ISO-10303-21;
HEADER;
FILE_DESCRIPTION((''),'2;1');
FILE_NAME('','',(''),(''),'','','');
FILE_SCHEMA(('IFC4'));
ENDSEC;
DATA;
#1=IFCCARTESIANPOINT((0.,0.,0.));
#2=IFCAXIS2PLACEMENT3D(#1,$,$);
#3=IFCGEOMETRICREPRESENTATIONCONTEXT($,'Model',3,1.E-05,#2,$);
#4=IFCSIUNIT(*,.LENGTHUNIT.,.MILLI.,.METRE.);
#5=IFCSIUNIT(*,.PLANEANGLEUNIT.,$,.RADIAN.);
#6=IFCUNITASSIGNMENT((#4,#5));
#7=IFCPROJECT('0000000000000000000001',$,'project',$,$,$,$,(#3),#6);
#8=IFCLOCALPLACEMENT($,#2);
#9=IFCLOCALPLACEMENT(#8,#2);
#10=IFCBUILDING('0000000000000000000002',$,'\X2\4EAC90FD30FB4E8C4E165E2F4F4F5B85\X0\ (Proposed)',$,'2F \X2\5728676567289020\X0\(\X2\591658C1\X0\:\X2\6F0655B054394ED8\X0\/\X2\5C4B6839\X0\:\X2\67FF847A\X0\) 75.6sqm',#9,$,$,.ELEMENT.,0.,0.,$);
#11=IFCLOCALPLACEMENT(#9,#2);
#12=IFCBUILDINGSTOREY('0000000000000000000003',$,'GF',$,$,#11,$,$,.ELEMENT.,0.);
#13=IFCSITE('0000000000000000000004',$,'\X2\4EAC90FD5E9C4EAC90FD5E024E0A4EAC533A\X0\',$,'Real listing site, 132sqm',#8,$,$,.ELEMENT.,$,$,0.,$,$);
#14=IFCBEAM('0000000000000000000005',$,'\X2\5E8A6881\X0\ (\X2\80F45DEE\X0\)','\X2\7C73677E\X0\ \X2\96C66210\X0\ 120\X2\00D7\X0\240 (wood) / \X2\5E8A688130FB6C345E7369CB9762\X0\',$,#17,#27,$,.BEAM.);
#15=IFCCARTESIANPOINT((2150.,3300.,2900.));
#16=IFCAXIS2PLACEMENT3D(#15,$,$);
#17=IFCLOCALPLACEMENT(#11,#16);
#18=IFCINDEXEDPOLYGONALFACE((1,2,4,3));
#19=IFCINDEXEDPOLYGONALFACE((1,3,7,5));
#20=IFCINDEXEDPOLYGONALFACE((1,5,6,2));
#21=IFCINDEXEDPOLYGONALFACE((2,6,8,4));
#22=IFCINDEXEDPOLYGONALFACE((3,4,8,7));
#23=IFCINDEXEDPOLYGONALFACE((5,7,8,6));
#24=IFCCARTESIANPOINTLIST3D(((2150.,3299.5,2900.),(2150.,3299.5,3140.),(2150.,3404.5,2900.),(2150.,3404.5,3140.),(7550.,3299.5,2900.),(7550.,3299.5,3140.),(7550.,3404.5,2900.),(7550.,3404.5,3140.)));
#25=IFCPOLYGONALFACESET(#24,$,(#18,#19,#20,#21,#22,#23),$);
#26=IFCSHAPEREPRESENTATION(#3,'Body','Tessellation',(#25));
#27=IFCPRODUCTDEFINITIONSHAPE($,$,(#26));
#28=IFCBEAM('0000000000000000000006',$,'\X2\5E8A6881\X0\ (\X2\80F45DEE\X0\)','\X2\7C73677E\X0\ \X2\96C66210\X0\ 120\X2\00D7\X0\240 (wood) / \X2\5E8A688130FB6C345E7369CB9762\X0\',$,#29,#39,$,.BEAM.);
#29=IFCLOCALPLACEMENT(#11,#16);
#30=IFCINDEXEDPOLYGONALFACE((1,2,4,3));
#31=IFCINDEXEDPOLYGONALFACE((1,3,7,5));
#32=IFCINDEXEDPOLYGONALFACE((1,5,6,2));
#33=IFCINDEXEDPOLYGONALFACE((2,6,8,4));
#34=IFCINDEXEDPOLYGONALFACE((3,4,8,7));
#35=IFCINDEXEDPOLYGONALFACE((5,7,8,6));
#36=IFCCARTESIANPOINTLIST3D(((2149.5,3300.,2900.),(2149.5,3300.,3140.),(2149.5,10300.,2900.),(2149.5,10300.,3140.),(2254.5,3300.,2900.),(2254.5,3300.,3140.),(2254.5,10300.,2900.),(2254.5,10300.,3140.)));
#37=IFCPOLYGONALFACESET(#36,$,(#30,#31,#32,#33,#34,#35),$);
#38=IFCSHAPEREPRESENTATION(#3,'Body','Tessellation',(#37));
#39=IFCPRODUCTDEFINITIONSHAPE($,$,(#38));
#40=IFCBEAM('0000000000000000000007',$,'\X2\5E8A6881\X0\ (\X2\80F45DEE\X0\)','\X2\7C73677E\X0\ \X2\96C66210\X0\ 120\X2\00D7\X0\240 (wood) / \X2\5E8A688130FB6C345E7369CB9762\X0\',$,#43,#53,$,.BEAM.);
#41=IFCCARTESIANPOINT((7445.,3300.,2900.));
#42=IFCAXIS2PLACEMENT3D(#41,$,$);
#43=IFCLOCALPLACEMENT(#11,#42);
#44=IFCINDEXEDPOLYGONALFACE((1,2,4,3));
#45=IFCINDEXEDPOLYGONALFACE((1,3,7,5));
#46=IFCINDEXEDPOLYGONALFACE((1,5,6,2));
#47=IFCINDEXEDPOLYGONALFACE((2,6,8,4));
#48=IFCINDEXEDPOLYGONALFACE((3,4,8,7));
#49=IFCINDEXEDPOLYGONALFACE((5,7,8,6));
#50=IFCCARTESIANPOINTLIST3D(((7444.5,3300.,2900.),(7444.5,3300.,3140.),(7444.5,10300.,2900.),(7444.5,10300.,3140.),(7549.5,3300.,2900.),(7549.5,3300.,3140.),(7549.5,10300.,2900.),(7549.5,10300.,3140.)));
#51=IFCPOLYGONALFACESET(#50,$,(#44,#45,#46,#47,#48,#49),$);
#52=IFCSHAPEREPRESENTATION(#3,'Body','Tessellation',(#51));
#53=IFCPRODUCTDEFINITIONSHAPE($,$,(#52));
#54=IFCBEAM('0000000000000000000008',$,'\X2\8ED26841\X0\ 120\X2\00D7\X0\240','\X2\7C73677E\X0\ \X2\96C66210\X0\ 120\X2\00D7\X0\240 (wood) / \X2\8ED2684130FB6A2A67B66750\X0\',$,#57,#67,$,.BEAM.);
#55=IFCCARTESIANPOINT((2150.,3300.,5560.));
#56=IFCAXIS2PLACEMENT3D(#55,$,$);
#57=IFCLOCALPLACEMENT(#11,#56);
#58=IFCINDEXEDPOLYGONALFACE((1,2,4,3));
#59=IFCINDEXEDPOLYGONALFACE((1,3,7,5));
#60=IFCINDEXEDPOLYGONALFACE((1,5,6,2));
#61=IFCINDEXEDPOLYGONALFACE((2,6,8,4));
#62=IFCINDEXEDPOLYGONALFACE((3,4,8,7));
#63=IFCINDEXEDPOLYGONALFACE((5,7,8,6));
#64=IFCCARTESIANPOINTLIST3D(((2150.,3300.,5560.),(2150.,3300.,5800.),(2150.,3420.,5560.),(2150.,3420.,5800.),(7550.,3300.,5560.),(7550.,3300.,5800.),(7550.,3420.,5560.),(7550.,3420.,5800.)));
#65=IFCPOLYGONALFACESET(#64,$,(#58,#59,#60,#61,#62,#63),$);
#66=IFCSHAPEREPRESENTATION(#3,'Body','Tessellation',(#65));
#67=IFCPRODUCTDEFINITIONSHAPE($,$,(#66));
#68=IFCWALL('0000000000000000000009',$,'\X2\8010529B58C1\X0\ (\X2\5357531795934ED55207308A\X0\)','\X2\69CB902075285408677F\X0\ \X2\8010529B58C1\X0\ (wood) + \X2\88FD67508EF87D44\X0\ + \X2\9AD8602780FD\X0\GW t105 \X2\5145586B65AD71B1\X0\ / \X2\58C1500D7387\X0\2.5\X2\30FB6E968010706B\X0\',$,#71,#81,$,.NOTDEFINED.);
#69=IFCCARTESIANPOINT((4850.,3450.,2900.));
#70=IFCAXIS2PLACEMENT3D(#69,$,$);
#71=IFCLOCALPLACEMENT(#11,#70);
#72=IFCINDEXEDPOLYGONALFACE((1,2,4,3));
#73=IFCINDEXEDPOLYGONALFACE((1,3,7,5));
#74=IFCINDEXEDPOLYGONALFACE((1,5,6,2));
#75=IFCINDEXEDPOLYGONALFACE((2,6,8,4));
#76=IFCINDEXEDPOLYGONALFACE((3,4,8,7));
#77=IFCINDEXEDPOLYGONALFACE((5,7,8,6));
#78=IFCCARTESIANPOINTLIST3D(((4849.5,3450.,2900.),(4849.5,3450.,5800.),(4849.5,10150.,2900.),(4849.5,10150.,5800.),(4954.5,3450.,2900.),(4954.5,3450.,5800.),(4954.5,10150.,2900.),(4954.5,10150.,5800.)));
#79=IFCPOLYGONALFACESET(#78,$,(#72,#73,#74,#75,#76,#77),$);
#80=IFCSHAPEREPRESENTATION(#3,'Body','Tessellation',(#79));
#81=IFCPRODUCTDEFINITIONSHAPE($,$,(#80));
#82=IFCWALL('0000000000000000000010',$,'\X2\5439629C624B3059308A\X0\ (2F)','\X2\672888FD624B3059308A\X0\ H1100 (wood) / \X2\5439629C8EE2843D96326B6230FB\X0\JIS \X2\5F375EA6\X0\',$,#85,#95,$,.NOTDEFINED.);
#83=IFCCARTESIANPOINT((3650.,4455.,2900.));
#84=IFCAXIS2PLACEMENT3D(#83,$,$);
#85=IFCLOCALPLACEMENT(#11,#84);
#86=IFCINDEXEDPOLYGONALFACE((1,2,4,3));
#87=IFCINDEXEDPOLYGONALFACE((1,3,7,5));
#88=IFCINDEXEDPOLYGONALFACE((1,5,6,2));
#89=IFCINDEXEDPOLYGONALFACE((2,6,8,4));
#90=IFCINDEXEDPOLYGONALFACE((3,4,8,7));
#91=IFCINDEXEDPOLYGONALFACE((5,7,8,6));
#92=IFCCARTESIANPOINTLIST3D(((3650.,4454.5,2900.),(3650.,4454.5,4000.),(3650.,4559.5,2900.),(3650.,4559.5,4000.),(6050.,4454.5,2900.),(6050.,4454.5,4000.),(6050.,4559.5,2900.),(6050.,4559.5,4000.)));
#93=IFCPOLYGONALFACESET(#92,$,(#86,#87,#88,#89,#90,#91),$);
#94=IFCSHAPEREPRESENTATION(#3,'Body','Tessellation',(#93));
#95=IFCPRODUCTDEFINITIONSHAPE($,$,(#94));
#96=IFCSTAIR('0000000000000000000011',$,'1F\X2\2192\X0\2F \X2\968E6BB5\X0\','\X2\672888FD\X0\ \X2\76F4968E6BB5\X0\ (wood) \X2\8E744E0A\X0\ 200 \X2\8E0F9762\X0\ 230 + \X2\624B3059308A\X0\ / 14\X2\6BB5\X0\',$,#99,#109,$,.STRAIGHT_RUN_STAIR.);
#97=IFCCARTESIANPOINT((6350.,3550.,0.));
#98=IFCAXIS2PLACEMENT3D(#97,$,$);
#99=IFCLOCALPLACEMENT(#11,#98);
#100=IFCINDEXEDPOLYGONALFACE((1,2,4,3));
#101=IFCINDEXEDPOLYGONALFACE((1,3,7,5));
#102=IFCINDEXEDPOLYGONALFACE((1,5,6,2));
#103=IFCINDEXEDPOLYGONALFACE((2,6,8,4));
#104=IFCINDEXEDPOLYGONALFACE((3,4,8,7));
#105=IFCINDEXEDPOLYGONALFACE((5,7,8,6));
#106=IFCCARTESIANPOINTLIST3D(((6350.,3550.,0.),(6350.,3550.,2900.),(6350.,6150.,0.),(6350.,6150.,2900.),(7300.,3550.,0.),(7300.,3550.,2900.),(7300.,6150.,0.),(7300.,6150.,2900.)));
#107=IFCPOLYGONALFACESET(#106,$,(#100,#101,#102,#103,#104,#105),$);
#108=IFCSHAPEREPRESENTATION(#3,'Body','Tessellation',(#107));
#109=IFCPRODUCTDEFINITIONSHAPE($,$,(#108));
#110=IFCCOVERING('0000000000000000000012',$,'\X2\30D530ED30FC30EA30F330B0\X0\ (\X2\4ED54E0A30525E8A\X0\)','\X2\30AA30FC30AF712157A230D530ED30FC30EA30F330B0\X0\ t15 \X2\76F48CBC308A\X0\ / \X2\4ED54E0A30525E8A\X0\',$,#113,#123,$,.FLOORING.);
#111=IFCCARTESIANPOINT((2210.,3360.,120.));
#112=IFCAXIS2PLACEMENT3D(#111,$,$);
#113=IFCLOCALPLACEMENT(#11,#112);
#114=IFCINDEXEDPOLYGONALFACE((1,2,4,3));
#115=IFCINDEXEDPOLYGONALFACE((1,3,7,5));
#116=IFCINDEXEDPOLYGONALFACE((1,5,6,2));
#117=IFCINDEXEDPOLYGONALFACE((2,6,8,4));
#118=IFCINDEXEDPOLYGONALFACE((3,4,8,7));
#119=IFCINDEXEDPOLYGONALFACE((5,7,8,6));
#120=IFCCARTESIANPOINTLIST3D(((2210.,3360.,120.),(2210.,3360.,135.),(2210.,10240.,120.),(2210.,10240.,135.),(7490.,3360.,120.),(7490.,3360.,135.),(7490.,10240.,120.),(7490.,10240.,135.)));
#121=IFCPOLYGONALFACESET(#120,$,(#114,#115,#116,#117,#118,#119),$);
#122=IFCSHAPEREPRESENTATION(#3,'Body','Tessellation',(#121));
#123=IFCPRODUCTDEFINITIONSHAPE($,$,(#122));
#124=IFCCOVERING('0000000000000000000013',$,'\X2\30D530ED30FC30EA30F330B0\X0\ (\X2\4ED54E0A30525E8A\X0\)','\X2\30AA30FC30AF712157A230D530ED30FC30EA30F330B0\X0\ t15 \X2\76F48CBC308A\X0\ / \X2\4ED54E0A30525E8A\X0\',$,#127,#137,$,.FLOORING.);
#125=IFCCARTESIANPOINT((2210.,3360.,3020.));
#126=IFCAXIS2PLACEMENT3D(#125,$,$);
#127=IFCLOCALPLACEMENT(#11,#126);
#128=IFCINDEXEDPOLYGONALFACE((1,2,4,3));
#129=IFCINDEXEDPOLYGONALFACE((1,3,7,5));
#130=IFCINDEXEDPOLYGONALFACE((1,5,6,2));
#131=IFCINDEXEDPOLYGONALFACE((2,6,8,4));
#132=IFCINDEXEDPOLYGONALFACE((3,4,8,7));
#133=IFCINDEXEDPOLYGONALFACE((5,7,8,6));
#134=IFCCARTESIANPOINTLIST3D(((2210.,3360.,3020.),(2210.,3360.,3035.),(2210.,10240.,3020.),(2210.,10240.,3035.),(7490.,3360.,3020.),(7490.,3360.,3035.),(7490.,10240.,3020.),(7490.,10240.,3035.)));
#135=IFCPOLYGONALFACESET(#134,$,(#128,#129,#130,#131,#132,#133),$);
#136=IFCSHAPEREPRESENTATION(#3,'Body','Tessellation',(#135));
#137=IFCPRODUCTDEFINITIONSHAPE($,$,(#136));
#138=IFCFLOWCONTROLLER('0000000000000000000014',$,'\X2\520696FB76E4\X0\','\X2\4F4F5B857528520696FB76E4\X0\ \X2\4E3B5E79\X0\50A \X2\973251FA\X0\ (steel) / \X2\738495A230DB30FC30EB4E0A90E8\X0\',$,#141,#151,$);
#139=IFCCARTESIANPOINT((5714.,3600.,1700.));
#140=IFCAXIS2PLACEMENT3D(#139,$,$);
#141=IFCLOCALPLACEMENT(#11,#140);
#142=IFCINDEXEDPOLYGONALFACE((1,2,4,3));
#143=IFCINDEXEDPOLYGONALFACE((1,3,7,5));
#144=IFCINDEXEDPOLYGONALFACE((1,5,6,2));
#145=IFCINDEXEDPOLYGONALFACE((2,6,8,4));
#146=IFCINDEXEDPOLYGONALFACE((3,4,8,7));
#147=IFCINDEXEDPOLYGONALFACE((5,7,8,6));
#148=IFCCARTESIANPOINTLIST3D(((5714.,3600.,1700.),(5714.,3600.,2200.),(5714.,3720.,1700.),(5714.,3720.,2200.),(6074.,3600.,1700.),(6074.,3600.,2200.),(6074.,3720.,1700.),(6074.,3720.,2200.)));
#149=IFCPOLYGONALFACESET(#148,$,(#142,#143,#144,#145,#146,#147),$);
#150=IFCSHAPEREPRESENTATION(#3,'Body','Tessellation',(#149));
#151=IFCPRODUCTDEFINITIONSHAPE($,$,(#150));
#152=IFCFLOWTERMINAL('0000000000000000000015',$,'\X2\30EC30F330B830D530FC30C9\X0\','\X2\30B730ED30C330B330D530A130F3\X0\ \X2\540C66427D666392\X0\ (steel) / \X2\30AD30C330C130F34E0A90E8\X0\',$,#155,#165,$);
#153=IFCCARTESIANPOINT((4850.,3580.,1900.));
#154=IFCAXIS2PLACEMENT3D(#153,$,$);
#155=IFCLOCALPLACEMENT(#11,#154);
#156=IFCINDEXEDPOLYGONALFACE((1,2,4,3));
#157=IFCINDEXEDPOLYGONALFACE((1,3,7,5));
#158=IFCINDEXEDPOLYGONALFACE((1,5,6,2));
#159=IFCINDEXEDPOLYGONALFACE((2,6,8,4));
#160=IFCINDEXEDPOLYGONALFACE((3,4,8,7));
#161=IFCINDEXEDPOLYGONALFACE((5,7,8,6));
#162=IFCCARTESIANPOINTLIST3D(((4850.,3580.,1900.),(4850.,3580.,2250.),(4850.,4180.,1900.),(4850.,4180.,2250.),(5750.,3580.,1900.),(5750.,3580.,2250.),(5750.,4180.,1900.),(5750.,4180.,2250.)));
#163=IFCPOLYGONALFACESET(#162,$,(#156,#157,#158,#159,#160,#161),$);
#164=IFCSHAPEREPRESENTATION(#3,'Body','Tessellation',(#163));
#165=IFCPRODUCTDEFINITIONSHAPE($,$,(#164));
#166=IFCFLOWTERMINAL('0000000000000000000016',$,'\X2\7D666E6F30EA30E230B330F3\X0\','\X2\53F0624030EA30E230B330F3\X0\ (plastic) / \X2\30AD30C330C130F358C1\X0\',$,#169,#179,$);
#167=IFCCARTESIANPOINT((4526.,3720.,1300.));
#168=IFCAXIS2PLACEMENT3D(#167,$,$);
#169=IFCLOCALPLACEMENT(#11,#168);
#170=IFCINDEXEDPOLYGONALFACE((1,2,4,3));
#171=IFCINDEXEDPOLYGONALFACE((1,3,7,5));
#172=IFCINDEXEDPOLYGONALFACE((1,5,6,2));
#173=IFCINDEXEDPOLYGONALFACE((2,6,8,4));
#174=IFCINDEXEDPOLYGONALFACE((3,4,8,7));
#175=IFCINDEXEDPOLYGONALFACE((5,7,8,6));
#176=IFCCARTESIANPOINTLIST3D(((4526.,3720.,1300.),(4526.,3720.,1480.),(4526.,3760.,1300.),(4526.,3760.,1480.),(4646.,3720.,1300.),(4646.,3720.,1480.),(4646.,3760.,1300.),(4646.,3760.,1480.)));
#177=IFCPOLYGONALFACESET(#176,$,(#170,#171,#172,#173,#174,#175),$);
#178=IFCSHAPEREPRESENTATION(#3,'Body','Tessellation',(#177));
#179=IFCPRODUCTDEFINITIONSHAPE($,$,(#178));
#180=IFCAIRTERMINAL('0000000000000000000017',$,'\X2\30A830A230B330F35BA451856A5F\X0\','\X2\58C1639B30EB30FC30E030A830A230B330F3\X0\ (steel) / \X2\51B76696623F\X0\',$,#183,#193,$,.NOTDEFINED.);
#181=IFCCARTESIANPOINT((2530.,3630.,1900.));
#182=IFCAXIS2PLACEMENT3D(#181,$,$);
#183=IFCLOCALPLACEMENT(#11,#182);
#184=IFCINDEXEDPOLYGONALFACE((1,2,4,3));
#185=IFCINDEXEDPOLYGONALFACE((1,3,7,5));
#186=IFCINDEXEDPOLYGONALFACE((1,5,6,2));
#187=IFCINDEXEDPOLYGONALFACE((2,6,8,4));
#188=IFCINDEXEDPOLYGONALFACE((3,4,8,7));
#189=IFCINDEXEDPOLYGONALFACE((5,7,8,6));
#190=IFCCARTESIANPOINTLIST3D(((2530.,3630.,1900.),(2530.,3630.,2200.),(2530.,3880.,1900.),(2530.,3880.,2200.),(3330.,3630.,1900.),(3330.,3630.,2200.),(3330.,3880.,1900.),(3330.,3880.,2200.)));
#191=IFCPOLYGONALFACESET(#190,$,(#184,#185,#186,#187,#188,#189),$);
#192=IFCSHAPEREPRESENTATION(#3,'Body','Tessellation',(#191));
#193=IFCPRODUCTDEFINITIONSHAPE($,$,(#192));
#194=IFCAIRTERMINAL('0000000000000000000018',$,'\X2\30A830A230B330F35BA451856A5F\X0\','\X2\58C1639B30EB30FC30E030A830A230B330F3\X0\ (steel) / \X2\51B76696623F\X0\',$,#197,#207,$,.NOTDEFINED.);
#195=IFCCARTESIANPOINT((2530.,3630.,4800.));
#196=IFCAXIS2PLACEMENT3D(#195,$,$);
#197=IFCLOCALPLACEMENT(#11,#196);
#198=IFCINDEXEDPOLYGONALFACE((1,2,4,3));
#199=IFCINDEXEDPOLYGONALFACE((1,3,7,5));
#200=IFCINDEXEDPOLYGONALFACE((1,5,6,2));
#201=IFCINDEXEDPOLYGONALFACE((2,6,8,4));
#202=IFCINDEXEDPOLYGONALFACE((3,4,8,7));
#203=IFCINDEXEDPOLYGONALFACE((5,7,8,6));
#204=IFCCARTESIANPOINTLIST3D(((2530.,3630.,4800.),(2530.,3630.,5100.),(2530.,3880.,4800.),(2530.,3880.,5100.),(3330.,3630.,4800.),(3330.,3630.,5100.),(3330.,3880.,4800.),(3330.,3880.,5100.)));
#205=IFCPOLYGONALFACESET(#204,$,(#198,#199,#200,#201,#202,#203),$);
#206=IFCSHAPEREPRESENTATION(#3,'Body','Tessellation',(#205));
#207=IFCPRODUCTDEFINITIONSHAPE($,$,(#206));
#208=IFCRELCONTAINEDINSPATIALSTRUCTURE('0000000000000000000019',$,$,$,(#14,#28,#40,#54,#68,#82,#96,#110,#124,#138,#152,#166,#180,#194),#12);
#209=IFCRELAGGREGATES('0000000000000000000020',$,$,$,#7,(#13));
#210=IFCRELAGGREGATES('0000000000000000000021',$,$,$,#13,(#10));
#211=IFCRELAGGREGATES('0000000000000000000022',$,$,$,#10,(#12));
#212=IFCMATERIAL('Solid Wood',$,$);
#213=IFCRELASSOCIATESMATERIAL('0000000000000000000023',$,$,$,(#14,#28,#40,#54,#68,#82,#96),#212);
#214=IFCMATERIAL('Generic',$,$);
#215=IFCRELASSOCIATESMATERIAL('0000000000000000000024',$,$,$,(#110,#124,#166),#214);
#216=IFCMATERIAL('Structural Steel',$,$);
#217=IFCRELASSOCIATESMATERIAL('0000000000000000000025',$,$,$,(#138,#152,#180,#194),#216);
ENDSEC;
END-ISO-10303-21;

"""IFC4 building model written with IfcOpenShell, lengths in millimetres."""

from ifc_helpers import new_model, si_unit, frame, frame_2d, origin, place, context, project, spatial, rectangle, extrude, material, element, save


model = new_model("IFC4")

# Units and contexts
model_context = context("Model", 3, precision=1e-05, world=origin())
ifc_project = project(units=[si_unit("LENGTHUNIT", "METRE", prefix="MILLI"), si_unit("PLANEANGLEUNIT", "RADIAN")], contexts=[model_context])

# Site, building, storey
site_placement = place(None, origin())
site = spatial("IfcSite", under=ifc_project, at=site_placement, Name="京都府京都市上京区", ObjectType="Real listing site, 132sqm", CompositionType="ELEMENT", RefElevation=0.0)
building_placement = place(site_placement, origin())
building = spatial("IfcBuilding", under=site, at=building_placement, Name="京都・二世帯住宅 (Proposed)", ObjectType="2F 在来木造(外壁:漆喰吹付/屋根:柿葺) 75.6sqm", CompositionType="ELEMENT", ElevationOfRefHeight=0.0, ElevationOfTerrain=0.0)
storey_placement = place(building_placement, origin())
storey = spatial("IfcBuildingStorey", under=building, at=storey_placement, Name="GF", CompositionType="ELEMENT", Elevation=0.0)

# Beams
ifc_material_1 = material(Name="Solid Wood")
beam_1_placement = place(storey_placement, frame((2150.0, 3300.0, 2900.0)))
element("IfcBeam", 1, at=beam_1_placement, inside=storey, material=ifc_material_1, Name="床梁 (胴差)", Description="米松 集成 120×240 (wood) / 床梁・水平構面", PredefinedType="BEAM", context=model_context, shape_type="SweptSolid", body=[
    extrude(rectangle(XDim=5400.0, YDim=105.0, at=frame_2d((2700.0, 52.0))), frame((2150.0, 3300.0, 2900.0)), (0.0, 0.0, 1.0), 240.0),
])
beam_2_placement = place(storey_placement, frame((2150.0, 3300.0, 2900.0)))
element("IfcBeam", 2, at=beam_2_placement, inside=storey, material=ifc_material_1, Name="床梁 (胴差)", Description="米松 集成 120×240 (wood) / 床梁・水平構面", PredefinedType="BEAM", context=model_context, shape_type="SweptSolid", body=[
    extrude(rectangle(XDim=105.0, YDim=7000.0, at=frame_2d((52.0, 3500.0))), frame((2150.0, 3300.0, 2900.0)), (0.0, 0.0, 1.0), 240.0),
])
beam_3_placement = place(storey_placement, frame((7445.0, 3300.0, 2900.0)))
element("IfcBeam", 3, at=beam_3_placement, inside=storey, material=ifc_material_1, Name="床梁 (胴差)", Description="米松 集成 120×240 (wood) / 床梁・水平構面", PredefinedType="BEAM", context=model_context, shape_type="SweptSolid", body=[
    extrude(rectangle(XDim=105.0, YDim=7000.0, at=frame_2d((52.0, 3500.0))), frame((7445.0, 3300.0, 2900.0)), (0.0, 0.0, 1.0), 240.0),
])
beam_4_placement = place(storey_placement, frame((2150.0, 3300.0, 5560.0)))
element("IfcBeam", 4, at=beam_4_placement, inside=storey, material=ifc_material_1, Name="軒桁 120×240", Description="米松 集成 120×240 (wood) / 軒桁・横架材", PredefinedType="BEAM", context=model_context, shape_type="SweptSolid", body=[
    extrude(rectangle(XDim=5400.0, YDim=120.0, at=frame_2d((2700.0, 60.0))), frame((2150.0, 3300.0, 5560.0)), (0.0, 0.0, 1.0), 240.0),
])

# Walls
wall_1_placement = place(storey_placement, frame((4850.0, 3450.0, 2900.0)))
element("IfcWall", 5, at=wall_1_placement, inside=storey, material=ifc_material_1, Name="耐力壁 (南北間仕切り)", Description="構造用合板 耐力壁 (wood) + 製材軸組 + 高性能GW t105 充填断熱 / 壁倍率2.5・準耐火", PredefinedType="NOTDEFINED", context=model_context, shape_type="SweptSolid", body=[
    extrude(rectangle(XDim=105.0, YDim=6700.0, at=frame_2d((52.0, 3350.0))), frame((4850.0, 3450.0, 2900.0)), (0.0, 0.0, 1.0), 2900.0),
])
wall_2_placement = place(storey_placement, frame((3650.0, 4455.0, 2900.0)))
element("IfcWall", 6, at=wall_2_placement, inside=storey, material=ifc_material_1, Name="吹抜手すり (2F)", Description="木製手すり H1100 (wood) / 吹抜転落防止・JIS 強度", PredefinedType="NOTDEFINED", context=model_context, shape_type="SweptSolid", body=[
    extrude(rectangle(XDim=2400.0, YDim=105.0, at=frame_2d((1200.0, 52.0))), frame((3650.0, 4455.0, 2900.0)), (0.0, 0.0, 1.0), 1100.0),
])

# Stair
stair_placement = place(storey_placement, frame((6350.0, 3550.0, 0.0)))
element("IfcStair", 7, at=stair_placement, inside=storey, material=ifc_material_1, Name="1F→2F 階段", Description="木製 直階段 (wood) 蹴上 200 踏面 230 + 手すり / 14段", PredefinedType="STRAIGHT_RUN_STAIR", context=model_context, shape_type="SweptSolid", body=[
    extrude(rectangle(XDim=950.0, YDim=2600.0, at=frame_2d((475.0, 1300.0))), frame((6350.0, 3550.0, 0.0)), (0.0, 0.0, 1.0), 2900.0),
])

# Coverings
ifc_material_2 = material(Name="Generic")
covering_1_placement = place(storey_placement, frame((2210.0, 3360.0, 120.0)))
element("IfcCovering", 8, at=covering_1_placement, inside=storey, material=ifc_material_2, Name="フローリング (仕上げ床)", Description="オーク無垢フローリング t15 直貼り / 仕上げ床", PredefinedType="FLOORING", context=model_context, shape_type="SweptSolid", body=[
    extrude(rectangle(XDim=5280.0, YDim=6880.0, at=frame_2d((2640.0, 3440.0))), frame((2210.0, 3360.0, 120.0)), (0.0, 0.0, 1.0), 15.0),
])
covering_2_placement = place(storey_placement, frame((2210.0, 3360.0, 3020.0)))
element("IfcCovering", 9, at=covering_2_placement, inside=storey, material=ifc_material_2, Name="フローリング (仕上げ床)", Description="オーク無垢フローリング t15 直貼り / 仕上げ床", PredefinedType="FLOORING", context=model_context, shape_type="SweptSolid", body=[
    extrude(rectangle(XDim=5280.0, YDim=6880.0, at=frame_2d((2640.0, 3440.0))), frame((2210.0, 3360.0, 3020.0)), (0.0, 0.0, 1.0), 15.0),
])

# Flow controller
ifc_material_3 = material(Name="Structural Steel")
flow_controller_placement = place(storey_placement, frame((5714.0, 3600.0, 1700.0)))
element("IfcFlowController", 10, at=flow_controller_placement, inside=storey, material=ifc_material_3, Name="分電盤", Description="住宅用分電盤 主幹50A 露出 (steel) / 玄関ホール上部", context=model_context, shape_type="SweptSolid", body=[
    extrude(rectangle(XDim=360.0, YDim=120.0, at=frame_2d((180.0, 60.0))), frame((5714.0, 3600.0, 1700.0)), (0.0, 0.0, 1.0), 500.0),
])

# Flow terminals
flow_terminal_1_placement = place(storey_placement, frame((4850.0, 3580.0, 1900.0)))
element("IfcFlowTerminal", 11, at=flow_terminal_1_placement, inside=storey, material=ifc_material_3, Name="レンジフード", Description="シロッコファン 同時給排 (steel) / キッチン上部", context=model_context, shape_type="SweptSolid", body=[
    extrude(rectangle(XDim=900.0, YDim=600.0, at=frame_2d((450.0, 300.0))), frame((4850.0, 3580.0, 1900.0)), (0.0, 0.0, 1.0), 350.0),
])
flow_terminal_2_placement = place(storey_placement, frame((4526.0, 3720.0, 1300.0)))
element("IfcFlowTerminal", 12, at=flow_terminal_2_placement, inside=storey, material=ifc_material_2, Name="給湯リモコン", Description="台所リモコン (plastic) / キッチン壁", context=model_context, shape_type="SweptSolid", body=[
    extrude(rectangle(XDim=120.0, YDim=40.0, at=frame_2d((60.0, 20.0))), frame((4526.0, 3720.0, 1300.0)), (0.0, 0.0, 1.0), 180.0),
])

# Air terminals
air_terminal_1_placement = place(storey_placement, frame((2530.0, 3630.0, 1900.0)))
element("IfcAirTerminal", 13, at=air_terminal_1_placement, inside=storey, material=ifc_material_3, Name="エアコン室内機", Description="壁掛ルームエアコン (steel) / 冷暖房", PredefinedType="NOTDEFINED", context=model_context, shape_type="SweptSolid", body=[
    extrude(rectangle(XDim=800.0, YDim=250.0, at=frame_2d((400.0, 125.0))), frame((2530.0, 3630.0, 1900.0)), (0.0, 0.0, 1.0), 300.0),
])
air_terminal_2_placement = place(storey_placement, frame((2530.0, 3630.0, 4800.0)))
element("IfcAirTerminal", 14, at=air_terminal_2_placement, inside=storey, material=ifc_material_3, Name="エアコン室内機", Description="壁掛ルームエアコン (steel) / 冷暖房", PredefinedType="NOTDEFINED", context=model_context, shape_type="SweptSolid", body=[
    extrude(rectangle(XDim=800.0, YDim=250.0, at=frame_2d((400.0, 125.0))), frame((2530.0, 3630.0, 4800.0)), (0.0, 0.0, 1.0), 300.0),
])

save(model, "model.ifc")
